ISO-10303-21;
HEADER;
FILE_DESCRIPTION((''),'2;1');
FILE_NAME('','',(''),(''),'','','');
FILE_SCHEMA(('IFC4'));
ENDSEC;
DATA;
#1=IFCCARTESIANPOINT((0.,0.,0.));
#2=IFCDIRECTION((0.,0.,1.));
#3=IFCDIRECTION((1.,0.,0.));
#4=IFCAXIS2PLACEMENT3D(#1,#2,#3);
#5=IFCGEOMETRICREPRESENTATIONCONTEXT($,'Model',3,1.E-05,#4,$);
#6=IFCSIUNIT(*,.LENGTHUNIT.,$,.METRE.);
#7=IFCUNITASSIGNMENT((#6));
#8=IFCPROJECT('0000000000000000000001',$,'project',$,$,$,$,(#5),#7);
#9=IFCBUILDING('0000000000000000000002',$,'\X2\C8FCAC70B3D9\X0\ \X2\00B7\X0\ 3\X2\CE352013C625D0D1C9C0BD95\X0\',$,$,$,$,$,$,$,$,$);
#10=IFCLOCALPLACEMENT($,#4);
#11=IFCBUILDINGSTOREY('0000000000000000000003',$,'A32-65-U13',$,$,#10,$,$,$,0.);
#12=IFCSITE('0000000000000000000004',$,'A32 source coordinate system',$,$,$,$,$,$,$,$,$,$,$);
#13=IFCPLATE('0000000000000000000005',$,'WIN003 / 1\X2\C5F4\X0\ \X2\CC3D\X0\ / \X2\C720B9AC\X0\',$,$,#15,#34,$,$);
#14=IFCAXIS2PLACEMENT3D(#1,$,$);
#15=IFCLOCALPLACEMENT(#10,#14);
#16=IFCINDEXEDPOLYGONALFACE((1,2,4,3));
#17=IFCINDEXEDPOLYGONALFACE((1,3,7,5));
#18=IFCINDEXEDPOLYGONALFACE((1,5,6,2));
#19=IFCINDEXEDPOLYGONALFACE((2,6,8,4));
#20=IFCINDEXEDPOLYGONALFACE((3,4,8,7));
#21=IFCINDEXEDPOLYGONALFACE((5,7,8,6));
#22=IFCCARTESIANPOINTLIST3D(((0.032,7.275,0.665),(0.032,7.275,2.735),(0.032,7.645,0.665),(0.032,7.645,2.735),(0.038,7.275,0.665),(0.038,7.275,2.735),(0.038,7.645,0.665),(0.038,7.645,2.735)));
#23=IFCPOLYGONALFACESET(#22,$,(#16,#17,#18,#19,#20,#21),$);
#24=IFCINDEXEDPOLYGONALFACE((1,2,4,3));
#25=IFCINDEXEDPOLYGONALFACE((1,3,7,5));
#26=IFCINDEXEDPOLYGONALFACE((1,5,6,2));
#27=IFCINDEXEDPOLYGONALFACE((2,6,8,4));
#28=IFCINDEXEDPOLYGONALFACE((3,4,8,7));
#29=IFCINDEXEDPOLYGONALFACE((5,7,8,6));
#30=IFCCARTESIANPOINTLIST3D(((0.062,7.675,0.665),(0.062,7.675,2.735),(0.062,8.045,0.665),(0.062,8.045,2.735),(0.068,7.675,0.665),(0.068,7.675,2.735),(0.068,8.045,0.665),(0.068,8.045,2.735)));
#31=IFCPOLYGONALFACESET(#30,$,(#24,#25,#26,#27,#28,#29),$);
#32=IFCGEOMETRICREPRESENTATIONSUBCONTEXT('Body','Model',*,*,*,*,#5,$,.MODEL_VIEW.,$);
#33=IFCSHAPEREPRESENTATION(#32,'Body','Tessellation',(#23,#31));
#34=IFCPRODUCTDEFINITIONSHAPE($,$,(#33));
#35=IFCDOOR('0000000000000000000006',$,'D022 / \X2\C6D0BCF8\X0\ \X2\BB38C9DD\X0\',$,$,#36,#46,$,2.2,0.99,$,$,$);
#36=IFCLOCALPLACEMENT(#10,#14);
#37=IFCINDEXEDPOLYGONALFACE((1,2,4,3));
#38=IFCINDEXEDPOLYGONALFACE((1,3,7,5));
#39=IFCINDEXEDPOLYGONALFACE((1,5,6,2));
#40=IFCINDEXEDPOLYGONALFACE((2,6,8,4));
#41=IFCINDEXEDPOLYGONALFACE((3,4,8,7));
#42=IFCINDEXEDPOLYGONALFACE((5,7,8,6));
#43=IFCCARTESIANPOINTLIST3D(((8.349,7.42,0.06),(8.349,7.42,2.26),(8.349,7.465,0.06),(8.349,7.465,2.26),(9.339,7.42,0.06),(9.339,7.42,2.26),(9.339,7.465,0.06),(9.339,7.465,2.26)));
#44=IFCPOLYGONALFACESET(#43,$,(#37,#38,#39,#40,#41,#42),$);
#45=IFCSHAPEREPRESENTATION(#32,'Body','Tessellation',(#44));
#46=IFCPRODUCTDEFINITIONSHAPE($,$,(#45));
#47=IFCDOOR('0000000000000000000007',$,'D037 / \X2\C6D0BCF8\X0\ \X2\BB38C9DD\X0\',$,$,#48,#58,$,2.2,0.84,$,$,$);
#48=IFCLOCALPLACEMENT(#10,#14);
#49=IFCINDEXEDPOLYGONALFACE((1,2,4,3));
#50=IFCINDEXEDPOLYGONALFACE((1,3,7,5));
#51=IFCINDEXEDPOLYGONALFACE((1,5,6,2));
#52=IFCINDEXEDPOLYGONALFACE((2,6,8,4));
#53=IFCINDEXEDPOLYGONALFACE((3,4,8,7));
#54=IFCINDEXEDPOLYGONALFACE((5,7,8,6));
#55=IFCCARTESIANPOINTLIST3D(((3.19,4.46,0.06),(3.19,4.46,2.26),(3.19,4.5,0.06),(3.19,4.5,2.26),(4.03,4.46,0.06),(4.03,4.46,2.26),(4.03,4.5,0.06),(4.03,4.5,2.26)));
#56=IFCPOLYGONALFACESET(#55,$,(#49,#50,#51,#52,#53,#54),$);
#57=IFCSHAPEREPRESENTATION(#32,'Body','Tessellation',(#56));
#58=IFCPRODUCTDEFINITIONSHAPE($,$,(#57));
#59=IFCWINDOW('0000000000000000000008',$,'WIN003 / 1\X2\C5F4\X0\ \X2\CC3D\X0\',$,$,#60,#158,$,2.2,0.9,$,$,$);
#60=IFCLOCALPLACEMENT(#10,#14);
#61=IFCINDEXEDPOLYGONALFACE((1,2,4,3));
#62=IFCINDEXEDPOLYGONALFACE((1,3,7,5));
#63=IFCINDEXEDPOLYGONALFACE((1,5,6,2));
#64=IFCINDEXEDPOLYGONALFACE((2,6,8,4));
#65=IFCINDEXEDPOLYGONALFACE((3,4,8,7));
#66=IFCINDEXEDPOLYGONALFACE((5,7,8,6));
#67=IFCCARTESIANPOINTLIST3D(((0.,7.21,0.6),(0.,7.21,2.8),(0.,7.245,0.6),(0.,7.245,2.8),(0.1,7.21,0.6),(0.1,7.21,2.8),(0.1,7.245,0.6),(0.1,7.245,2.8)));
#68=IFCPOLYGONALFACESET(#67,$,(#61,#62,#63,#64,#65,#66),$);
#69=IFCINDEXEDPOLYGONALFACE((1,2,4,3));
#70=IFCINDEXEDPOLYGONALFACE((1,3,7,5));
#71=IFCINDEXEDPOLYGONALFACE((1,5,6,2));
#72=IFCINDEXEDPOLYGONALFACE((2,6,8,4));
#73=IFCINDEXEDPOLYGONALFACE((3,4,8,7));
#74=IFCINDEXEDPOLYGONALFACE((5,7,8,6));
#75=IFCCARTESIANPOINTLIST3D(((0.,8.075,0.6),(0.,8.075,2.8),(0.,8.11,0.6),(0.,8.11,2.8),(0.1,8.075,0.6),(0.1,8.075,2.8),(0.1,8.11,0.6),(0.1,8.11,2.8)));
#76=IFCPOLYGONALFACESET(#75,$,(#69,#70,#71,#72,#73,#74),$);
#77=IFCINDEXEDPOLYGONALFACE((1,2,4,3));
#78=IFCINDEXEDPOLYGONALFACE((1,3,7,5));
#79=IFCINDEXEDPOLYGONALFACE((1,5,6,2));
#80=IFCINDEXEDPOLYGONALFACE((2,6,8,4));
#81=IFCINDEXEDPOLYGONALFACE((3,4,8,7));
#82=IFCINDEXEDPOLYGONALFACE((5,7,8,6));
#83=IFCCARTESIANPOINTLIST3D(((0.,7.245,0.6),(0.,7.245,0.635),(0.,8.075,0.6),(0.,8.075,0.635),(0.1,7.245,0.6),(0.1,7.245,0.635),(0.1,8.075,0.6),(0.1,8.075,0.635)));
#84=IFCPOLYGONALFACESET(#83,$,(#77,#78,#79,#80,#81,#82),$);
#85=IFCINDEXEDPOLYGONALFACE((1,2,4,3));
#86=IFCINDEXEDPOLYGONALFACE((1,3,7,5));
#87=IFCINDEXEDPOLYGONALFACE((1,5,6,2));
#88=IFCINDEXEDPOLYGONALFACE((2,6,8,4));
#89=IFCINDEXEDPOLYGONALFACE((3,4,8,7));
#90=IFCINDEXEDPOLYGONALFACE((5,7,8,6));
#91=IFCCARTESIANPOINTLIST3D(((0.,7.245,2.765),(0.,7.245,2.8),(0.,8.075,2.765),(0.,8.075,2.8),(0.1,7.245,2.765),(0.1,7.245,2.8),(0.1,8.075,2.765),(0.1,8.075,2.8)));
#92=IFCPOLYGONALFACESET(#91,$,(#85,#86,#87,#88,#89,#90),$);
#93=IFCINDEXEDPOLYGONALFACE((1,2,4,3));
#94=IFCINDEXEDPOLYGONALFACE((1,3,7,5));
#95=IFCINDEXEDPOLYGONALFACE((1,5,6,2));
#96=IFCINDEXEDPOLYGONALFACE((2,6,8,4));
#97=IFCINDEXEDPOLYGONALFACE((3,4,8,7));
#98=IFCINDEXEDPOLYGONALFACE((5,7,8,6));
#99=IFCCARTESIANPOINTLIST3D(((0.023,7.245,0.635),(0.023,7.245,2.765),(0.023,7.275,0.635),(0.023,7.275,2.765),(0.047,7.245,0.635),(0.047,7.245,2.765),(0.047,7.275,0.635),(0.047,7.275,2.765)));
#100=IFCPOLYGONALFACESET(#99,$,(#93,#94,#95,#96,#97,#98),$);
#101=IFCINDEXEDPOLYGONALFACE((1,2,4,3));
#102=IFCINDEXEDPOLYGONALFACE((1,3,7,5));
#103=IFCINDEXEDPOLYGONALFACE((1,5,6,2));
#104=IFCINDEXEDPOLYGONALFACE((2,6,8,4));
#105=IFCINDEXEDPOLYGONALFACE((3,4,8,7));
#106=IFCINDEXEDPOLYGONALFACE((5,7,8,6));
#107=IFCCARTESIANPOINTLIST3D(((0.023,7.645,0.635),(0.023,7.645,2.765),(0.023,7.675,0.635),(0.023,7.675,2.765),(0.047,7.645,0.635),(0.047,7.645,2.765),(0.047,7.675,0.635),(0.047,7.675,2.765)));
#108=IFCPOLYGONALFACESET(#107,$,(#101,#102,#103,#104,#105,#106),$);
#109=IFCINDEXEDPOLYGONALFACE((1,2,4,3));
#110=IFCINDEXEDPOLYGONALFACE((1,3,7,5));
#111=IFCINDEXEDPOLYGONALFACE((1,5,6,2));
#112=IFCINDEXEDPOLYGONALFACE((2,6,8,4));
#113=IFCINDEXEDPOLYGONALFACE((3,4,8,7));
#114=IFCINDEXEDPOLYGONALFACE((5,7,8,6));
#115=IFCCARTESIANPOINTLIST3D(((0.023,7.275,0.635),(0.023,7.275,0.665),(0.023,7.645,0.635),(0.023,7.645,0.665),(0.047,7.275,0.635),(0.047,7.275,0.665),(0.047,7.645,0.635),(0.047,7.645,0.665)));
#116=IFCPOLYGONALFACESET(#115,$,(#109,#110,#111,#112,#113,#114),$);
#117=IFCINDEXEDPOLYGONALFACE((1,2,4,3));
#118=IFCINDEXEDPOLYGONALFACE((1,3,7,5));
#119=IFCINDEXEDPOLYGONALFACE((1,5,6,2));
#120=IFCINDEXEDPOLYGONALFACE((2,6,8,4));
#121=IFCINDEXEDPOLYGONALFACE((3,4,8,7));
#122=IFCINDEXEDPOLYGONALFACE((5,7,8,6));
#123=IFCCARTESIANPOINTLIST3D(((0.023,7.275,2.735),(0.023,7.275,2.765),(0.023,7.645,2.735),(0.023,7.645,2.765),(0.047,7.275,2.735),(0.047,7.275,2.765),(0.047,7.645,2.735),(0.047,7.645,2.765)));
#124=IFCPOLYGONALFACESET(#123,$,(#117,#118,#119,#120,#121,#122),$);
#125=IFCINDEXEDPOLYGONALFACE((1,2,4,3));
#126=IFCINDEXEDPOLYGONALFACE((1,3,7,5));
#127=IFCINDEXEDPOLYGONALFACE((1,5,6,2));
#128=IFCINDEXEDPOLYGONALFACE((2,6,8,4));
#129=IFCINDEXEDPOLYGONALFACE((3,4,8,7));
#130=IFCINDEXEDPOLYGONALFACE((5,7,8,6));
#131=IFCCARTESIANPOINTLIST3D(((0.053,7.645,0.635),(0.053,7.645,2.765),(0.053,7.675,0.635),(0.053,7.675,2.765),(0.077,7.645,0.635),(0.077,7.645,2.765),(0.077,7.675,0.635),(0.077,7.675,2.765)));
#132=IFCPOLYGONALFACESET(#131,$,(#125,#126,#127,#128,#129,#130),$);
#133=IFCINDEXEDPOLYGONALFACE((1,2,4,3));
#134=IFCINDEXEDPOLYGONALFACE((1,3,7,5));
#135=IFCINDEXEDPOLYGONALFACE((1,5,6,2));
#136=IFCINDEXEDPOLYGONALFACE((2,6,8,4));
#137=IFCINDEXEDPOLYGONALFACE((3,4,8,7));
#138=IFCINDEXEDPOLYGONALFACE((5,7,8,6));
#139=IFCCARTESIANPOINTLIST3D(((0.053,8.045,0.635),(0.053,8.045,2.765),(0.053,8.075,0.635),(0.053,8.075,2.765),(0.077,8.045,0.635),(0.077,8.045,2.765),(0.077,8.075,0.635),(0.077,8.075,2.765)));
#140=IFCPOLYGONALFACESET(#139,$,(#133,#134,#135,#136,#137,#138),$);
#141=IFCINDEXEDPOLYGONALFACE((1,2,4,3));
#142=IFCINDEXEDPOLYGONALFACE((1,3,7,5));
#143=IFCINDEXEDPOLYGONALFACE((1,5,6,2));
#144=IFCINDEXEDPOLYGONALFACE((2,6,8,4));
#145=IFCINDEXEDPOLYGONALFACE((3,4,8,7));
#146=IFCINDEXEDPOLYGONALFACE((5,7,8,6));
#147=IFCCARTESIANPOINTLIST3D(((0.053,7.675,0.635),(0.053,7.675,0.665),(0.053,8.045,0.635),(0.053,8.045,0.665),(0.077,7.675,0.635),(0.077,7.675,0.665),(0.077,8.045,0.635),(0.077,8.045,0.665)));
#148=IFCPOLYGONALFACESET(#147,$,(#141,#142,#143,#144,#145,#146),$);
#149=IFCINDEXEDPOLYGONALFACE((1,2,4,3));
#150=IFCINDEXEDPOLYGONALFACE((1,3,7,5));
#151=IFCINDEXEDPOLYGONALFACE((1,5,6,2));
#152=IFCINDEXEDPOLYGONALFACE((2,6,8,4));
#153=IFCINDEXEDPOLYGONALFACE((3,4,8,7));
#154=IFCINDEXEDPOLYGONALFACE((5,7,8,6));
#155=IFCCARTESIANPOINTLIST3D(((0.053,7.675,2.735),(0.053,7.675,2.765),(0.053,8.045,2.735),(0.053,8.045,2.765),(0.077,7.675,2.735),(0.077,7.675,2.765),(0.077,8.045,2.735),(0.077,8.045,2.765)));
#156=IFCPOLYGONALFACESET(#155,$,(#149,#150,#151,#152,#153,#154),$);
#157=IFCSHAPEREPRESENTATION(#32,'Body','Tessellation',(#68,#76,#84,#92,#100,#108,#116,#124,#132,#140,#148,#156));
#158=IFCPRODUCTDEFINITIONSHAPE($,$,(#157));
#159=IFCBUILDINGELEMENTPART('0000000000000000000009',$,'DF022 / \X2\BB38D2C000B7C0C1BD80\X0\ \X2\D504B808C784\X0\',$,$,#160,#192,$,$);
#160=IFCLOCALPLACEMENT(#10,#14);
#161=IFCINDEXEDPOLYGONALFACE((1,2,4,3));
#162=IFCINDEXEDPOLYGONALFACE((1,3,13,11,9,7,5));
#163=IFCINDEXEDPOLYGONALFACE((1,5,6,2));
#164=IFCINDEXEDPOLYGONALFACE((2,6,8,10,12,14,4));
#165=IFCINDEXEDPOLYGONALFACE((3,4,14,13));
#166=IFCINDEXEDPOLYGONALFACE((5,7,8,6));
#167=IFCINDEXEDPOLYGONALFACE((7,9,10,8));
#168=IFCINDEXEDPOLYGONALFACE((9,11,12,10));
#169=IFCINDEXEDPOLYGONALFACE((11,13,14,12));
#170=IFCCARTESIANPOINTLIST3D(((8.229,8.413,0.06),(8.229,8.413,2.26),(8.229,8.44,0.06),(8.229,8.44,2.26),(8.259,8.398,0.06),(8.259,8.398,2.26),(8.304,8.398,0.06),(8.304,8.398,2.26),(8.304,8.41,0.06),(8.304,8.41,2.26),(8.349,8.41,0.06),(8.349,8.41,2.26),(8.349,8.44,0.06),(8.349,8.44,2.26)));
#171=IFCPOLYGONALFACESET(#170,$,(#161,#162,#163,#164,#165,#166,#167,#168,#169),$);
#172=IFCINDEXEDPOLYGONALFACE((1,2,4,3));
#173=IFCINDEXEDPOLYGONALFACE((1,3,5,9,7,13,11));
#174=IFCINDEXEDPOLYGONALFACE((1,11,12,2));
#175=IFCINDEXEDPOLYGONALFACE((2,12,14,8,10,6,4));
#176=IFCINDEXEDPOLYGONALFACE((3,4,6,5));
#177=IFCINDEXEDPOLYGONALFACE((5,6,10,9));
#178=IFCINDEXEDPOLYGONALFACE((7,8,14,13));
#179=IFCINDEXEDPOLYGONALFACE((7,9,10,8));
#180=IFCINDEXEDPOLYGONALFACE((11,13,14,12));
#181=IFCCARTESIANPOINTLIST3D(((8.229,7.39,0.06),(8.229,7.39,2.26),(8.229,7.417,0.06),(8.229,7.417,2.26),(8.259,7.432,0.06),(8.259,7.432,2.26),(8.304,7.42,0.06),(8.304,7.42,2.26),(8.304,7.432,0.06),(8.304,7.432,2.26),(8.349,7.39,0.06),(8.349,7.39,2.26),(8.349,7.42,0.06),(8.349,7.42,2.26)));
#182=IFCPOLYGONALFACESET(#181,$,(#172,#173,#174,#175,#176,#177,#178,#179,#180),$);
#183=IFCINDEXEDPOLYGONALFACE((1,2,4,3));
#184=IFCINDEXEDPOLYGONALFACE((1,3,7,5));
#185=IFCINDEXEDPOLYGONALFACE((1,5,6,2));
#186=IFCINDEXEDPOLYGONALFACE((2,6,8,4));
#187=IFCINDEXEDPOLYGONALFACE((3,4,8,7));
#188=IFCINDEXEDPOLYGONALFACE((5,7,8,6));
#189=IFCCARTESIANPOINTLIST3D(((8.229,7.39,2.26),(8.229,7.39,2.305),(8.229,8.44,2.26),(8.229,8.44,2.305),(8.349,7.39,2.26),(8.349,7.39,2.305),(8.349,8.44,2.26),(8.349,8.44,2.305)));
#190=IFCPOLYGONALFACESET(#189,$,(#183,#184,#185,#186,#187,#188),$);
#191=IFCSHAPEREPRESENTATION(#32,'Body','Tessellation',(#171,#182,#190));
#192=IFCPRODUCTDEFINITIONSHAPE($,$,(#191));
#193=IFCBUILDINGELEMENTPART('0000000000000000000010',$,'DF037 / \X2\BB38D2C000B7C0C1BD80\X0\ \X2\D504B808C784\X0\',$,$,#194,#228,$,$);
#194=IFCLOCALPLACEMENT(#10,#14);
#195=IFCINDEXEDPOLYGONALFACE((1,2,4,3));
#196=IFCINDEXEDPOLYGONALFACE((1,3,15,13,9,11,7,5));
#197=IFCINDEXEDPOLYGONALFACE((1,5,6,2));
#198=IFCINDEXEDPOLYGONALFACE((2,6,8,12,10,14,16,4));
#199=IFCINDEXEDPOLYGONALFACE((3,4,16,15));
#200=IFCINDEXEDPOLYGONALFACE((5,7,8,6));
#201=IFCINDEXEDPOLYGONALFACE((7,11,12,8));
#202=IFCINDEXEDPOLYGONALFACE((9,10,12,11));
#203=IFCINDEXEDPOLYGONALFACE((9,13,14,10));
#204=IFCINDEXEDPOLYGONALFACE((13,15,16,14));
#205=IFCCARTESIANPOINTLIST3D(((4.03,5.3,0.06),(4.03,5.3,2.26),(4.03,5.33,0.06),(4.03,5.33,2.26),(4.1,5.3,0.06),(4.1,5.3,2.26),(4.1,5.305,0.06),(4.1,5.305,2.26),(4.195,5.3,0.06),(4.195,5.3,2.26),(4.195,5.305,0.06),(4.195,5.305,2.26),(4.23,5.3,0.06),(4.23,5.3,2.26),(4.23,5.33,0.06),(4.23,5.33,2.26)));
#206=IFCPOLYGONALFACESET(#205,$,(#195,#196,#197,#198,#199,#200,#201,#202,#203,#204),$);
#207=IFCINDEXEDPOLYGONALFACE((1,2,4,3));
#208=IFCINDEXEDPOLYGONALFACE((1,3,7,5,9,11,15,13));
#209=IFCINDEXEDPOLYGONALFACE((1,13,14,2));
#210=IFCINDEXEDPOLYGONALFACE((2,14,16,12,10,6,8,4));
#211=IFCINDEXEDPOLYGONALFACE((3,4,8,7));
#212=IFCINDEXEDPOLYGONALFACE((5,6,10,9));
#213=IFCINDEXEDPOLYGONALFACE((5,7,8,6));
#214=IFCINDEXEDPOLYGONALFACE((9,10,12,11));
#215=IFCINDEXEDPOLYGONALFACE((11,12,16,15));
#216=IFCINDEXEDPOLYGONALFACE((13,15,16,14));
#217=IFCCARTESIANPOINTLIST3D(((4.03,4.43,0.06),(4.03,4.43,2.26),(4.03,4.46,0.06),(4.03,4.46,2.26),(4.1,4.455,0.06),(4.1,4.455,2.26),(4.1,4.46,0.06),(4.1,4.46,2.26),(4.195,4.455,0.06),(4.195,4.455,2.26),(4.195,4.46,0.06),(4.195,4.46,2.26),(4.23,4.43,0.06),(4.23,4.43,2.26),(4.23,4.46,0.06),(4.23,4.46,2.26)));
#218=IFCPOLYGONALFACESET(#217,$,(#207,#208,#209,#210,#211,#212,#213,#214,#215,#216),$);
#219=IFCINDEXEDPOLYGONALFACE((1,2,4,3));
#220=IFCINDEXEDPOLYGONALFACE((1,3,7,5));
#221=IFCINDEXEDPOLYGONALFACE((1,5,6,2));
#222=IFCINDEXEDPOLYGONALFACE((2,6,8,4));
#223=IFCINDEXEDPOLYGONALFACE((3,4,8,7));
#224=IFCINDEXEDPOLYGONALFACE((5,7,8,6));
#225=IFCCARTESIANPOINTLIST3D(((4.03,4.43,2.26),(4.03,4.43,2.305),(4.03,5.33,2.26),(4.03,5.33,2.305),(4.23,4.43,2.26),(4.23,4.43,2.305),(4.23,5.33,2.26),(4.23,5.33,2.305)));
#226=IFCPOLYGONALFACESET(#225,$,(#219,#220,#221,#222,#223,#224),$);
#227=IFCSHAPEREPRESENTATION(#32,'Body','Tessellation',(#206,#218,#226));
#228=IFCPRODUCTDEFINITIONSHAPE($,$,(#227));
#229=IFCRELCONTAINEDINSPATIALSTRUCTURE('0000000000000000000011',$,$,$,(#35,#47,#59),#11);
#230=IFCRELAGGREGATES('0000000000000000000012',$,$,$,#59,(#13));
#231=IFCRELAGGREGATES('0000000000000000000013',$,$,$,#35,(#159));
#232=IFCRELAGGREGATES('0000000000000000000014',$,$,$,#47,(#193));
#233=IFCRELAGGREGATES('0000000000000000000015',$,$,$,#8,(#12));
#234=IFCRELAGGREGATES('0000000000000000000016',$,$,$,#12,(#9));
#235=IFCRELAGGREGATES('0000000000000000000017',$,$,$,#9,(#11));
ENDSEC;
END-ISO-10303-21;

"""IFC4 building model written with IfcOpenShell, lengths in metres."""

from ifc_helpers import new_model, si_unit, frame, origin_with_axes, place, context, subcontext, project, spatial, polyline, outline, extrude, element, aggregate, save


model = new_model("IFC4")

# Units and contexts
model_context = context("Model", 3, precision=1e-05, world=origin_with_axes())
body_context = subcontext(model_context, "Body", "Model", "MODEL_VIEW")
ifc_project = project(units=[si_unit("LENGTHUNIT", "METRE")], contexts=[model_context])

# Plate
storey_placement = place(None, origin_with_axes())
window_1_placement = place(storey_placement, origin_with_axes())
plate_1_placement = place(window_1_placement, origin_with_axes())
plate_1 = element("IfcPlate", 1, at=plate_1_placement, Name="WIN003 / 1열 창 / 유리", context=body_context, shape_type="SweptSolid", body=[
    extrude(outline(polyline([(0.032, 7.275), (0.032, 7.645), (0.038, 7.645), (0.038, 7.275), (0.032, 7.275)])), frame((0.0, 0.0, 0.665)), (0.0, 0.0, 1.0), 2.07),
    extrude(outline(polyline([(0.062, 7.675), (0.062, 8.045), (0.068, 8.045), (0.068, 7.675), (0.062, 7.675)])), frame((0.0, 0.0, 0.665)), (0.0, 0.0, 1.0), 2.07),
])

# Site, building, storey
site = spatial("IfcSite", under=ifc_project, Name="A32 source coordinate system")
building = spatial("IfcBuilding", under=site, Name="주거동 · 3층–옥탑지붕")
storey = spatial("IfcBuildingStorey", under=building, at=storey_placement, Name="A32-65-U13", Elevation=0.0)

# Doors
door_1_placement = place(storey_placement, origin_with_axes())
door_1 = element("IfcDoor", 2, at=door_1_placement, inside=storey, Name="D022 / 원본 문짝", OverallHeight=2.2, OverallWidth=0.99, context=body_context, shape_type="SweptSolid", body=[
    extrude(outline(polyline([(9.339, 7.465), (9.339, 7.42), (8.349, 7.42), (8.349, 7.465), (9.339, 7.465)])), frame((0.0, 0.0, 0.06)), (0.0, 0.0, 1.0), 2.2),
])
door_2_placement = place(storey_placement, origin_with_axes())
door_2 = element("IfcDoor", 3, at=door_2_placement, inside=storey, Name="D037 / 원본 문짝", OverallHeight=2.2, OverallWidth=0.84, context=body_context, shape_type="SweptSolid", body=[
    extrude(outline(polyline([(4.03, 4.46), (3.19, 4.46), (3.19, 4.5), (4.03, 4.5), (4.03, 4.46)])), frame((0.0, 0.0, 0.06)), (0.0, 0.0, 1.0), 2.2),
])

# Window
window_1 = element("IfcWindow", 4, at=window_1_placement, inside=storey, Name="WIN003 / 1열 창", OverallHeight=2.2, OverallWidth=0.9, context=body_context, shape_type="SweptSolid", body=[
    extrude(outline(polyline([(0.0, 7.21), (0.0, 7.245), (0.1, 7.245), (0.1, 7.21), (0.0, 7.21)])), frame((0.0, 0.0, 0.6)), (0.0, 0.0, 1.0), 2.2),
    extrude(outline(polyline([(0.0, 8.075), (0.0, 8.11), (0.1, 8.11), (0.1, 8.075), (0.0, 8.075)])), frame((0.0, 0.0, 0.6)), (0.0, 0.0, 1.0), 2.2),
    extrude(outline(polyline([(0.0, 7.245), (0.0, 8.075), (0.1, 8.075), (0.1, 7.245), (0.0, 7.245)])), frame((0.0, 0.0, 0.6)), (0.0, 0.0, 1.0), 0.035),
    extrude(outline(polyline([(0.0, 7.245), (0.0, 8.075), (0.1, 8.075), (0.1, 7.245), (0.0, 7.245)])), frame((0.0, 0.0, 2.765)), (0.0, 0.0, 1.0), 0.035),
    extrude(outline(polyline([(0.023, 7.245), (0.023, 7.275), (0.047, 7.275), (0.047, 7.245), (0.023, 7.245)])), frame((0.0, 0.0, 0.635)), (0.0, 0.0, 1.0), 2.13),
    extrude(outline(polyline([(0.023, 7.645), (0.023, 7.675), (0.047, 7.675), (0.047, 7.645), (0.023, 7.645)])), frame((0.0, 0.0, 0.635)), (0.0, 0.0, 1.0), 2.13),
    extrude(outline(polyline([(0.023, 7.275), (0.023, 7.645), (0.047, 7.645), (0.047, 7.275), (0.023, 7.275)])), frame((0.0, 0.0, 0.635)), (0.0, 0.0, 1.0), 0.03),
    extrude(outline(polyline([(0.023, 7.275), (0.023, 7.645), (0.047, 7.645), (0.047, 7.275), (0.023, 7.275)])), frame((0.0, 0.0, 2.735)), (0.0, 0.0, 1.0), 0.03),
    extrude(outline(polyline([(0.053, 7.645), (0.053, 7.675), (0.077, 7.675), (0.077, 7.645), (0.053, 7.645)])), frame((0.0, 0.0, 0.635)), (0.0, 0.0, 1.0), 2.13),
    extrude(outline(polyline([(0.053, 8.045), (0.053, 8.075), (0.077, 8.075), (0.077, 8.045), (0.053, 8.045)])), frame((0.0, 0.0, 0.635)), (0.0, 0.0, 1.0), 2.13),
    extrude(outline(polyline([(0.053, 7.675), (0.053, 8.045), (0.077, 8.045), (0.077, 7.675), (0.053, 7.675)])), frame((0.0, 0.0, 0.635)), (0.0, 0.0, 1.0), 0.03),
    extrude(outline(polyline([(0.053, 7.675), (0.053, 8.045), (0.077, 8.045), (0.077, 7.675), (0.053, 7.675)])), frame((0.0, 0.0, 2.735)), (0.0, 0.0, 1.0), 0.03),
])
aggregate(window_1, [plate_1])

# Building element parts
building_element_part_1_placement = place(door_1_placement, origin_with_axes())
building_element_part_1 = element("IfcBuildingElementPart", 5, at=building_element_part_1_placement, Name="DF022 / 문틀·상부 프레임", context=body_context, shape_type="SweptSolid", body=[
    extrude(outline(polyline([(8.349, 8.41), (8.304, 8.41), (8.304, 8.398), (8.259, 8.398), (8.229, 8.413), (8.229, 8.44), (8.349, 8.44), (8.349, 8.41)])), frame((0.0, 0.0, 0.06)), (0.0, 0.0, 1.0), 2.2),
    extrude(outline(polyline([(8.229, 7.39), (8.229, 7.417), (8.259, 7.432), (8.304, 7.432), (8.304, 7.42), (8.349, 7.42), (8.349, 7.39), (8.229, 7.39)])), frame((0.0, 0.0, 0.06)), (0.0, 0.0, 1.0), 2.2),
    extrude(outline(polyline([(8.229, 7.39), (8.229, 8.44), (8.349, 8.44), (8.349, 7.39), (8.229, 7.39)])), frame((0.0, 0.0, 2.26)), (0.0, 0.0, 1.0), 0.045),
])
aggregate(door_1, [building_element_part_1])
building_element_part_2_placement = place(door_2_placement, origin_with_axes())
building_element_part_2 = element("IfcBuildingElementPart", 6, at=building_element_part_2_placement, Name="DF037 / 문틀·상부 프레임", context=body_context, shape_type="SweptSolid", body=[
    extrude(outline(polyline([(4.23, 5.33), (4.23, 5.3), (4.195, 5.3), (4.195, 5.305), (4.1, 5.305), (4.1, 5.3), (4.03, 5.3), (4.03, 5.33), (4.23, 5.33)])), frame((0.0, 0.0, 0.06)), (0.0, 0.0, 1.0), 2.2),
    extrude(outline(polyline([(4.03, 4.46), (4.1, 4.46), (4.1, 4.455), (4.195, 4.455), (4.195, 4.46), (4.23, 4.46), (4.23, 4.43), (4.03, 4.43), (4.03, 4.46)])), frame((0.0, 0.0, 0.06)), (0.0, 0.0, 1.0), 2.2),
    extrude(outline(polyline([(4.03, 4.43), (4.03, 5.33), (4.23, 5.33), (4.23, 4.43), (4.03, 4.43)])), frame((0.0, 0.0, 2.26)), (0.0, 0.0, 1.0), 0.045),
])
aggregate(door_2, [building_element_part_2])

save(model, "model.ifc")
